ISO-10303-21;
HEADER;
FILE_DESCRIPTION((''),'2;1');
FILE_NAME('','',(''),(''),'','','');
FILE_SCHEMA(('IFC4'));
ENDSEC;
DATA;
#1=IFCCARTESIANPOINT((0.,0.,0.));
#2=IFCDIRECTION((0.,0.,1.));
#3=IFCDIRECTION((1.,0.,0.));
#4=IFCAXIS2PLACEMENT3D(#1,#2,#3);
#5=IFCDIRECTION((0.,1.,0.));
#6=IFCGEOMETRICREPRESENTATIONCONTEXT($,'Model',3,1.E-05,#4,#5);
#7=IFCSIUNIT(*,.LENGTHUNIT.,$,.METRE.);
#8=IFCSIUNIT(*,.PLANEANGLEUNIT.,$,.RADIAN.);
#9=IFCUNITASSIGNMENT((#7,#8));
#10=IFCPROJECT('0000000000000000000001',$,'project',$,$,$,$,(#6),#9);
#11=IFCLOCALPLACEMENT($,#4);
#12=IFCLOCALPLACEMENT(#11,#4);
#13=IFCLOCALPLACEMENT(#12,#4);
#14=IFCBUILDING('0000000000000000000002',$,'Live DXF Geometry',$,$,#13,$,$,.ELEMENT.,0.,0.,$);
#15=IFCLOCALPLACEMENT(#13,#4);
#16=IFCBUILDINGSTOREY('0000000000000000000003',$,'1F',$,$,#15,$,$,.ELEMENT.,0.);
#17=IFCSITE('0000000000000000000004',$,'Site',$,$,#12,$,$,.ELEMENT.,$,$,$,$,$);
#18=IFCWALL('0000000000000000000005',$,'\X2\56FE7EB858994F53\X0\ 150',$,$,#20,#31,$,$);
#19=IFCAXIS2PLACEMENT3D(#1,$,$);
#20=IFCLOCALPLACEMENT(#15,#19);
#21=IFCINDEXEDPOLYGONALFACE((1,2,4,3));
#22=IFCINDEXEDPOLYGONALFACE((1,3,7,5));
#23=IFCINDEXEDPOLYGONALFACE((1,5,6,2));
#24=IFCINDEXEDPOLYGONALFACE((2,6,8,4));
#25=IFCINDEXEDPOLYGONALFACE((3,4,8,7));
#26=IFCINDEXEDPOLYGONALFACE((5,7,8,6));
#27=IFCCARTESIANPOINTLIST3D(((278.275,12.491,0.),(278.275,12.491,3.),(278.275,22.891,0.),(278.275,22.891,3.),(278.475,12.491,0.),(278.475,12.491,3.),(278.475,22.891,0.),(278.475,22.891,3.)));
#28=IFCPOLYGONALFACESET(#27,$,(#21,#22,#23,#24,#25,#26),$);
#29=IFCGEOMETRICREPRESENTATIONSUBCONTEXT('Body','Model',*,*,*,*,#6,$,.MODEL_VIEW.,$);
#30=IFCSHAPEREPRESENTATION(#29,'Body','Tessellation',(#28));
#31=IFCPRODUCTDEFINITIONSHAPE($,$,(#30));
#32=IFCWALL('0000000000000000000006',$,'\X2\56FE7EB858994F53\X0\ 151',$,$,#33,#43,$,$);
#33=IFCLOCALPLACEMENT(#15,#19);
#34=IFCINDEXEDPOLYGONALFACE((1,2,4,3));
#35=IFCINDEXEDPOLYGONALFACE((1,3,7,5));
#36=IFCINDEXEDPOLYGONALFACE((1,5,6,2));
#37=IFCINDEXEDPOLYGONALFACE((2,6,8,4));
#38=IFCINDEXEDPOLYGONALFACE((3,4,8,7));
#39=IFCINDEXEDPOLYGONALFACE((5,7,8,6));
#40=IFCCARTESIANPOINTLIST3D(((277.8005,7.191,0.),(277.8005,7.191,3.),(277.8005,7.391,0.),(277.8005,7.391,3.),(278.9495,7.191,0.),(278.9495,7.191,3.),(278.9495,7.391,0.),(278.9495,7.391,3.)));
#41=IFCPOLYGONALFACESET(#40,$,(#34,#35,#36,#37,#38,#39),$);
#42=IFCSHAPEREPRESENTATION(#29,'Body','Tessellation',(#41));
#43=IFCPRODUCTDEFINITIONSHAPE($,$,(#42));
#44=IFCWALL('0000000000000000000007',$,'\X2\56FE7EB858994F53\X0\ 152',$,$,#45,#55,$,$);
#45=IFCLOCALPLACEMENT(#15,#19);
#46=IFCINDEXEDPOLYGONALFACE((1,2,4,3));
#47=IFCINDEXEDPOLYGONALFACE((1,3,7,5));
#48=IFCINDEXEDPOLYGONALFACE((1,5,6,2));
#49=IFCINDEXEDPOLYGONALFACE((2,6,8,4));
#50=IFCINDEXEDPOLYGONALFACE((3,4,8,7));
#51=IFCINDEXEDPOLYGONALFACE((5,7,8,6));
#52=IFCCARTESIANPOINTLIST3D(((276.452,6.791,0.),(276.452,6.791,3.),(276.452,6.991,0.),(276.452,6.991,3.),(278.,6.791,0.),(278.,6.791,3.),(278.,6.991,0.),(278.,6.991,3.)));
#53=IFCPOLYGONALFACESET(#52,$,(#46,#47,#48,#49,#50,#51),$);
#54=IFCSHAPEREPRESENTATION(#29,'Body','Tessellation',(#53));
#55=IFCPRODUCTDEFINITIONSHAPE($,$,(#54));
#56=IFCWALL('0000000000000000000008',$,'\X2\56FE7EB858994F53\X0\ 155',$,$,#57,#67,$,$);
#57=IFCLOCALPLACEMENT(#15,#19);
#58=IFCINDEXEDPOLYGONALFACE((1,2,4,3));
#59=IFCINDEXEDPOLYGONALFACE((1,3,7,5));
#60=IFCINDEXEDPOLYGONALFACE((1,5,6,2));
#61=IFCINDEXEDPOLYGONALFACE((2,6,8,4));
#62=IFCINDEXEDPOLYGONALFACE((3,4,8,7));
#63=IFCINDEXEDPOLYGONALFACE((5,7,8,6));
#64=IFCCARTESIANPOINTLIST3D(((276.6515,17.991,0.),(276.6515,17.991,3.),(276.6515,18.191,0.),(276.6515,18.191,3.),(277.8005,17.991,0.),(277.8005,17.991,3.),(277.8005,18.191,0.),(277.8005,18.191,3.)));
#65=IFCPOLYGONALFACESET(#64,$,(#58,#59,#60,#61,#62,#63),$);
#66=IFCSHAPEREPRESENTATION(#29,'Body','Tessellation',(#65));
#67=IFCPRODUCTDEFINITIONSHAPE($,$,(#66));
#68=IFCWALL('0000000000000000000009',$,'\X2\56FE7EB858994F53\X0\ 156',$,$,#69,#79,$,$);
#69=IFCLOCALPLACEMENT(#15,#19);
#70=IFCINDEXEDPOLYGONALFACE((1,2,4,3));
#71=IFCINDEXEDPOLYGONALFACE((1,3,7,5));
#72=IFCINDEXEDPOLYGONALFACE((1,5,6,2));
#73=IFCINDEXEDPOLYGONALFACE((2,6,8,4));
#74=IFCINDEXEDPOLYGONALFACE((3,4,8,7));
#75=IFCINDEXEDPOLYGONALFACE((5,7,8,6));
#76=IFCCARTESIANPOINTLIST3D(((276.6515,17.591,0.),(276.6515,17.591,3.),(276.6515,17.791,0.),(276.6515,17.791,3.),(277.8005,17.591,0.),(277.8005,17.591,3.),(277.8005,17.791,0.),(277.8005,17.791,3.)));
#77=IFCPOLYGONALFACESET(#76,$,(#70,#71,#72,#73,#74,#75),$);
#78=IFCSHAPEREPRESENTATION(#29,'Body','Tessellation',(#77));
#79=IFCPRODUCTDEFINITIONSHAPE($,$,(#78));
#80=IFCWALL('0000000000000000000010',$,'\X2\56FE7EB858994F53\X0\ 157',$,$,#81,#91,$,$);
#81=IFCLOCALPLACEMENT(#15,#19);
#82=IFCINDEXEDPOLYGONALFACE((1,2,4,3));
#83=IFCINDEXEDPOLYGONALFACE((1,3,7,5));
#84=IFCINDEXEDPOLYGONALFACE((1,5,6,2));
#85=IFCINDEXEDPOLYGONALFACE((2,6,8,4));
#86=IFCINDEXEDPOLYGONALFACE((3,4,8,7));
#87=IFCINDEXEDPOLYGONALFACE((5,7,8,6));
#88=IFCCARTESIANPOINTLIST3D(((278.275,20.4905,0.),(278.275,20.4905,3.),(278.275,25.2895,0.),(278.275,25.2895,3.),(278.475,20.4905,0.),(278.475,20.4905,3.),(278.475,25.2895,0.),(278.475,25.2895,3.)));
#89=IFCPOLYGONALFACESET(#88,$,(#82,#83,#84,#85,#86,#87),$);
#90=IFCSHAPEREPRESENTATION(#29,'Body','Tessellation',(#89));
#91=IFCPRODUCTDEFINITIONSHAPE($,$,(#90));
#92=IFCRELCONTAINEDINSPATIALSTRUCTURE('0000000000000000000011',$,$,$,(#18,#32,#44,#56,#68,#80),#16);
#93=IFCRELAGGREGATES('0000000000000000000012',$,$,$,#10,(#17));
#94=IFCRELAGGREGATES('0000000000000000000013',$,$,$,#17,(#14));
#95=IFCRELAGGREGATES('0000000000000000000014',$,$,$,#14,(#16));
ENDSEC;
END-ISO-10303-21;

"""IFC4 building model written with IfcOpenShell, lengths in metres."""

from ifc_helpers import new_model, si_unit, direction, frame, frame_2d, origin_with_axes, place, context, subcontext, project, spatial, rectangle, extrude, element, save


model = new_model("IFC4")

# Units and contexts
model_context = context("Model", 3, precision=1e-05, world=origin_with_axes(), true_north=direction((0.0, 1.0, 0.0)))
body_context = subcontext(model_context, "Body", "Model", "MODEL_VIEW")
ifc_project = project(units=[si_unit("LENGTHUNIT", "METRE"), si_unit("PLANEANGLEUNIT", "RADIAN")], contexts=[model_context])

# Site, building, storey
placement = place(None, origin_with_axes())
site_placement = place(placement, origin_with_axes())
site = spatial("IfcSite", under=ifc_project, at=site_placement, Name="Site", CompositionType="ELEMENT")
building_placement = place(site_placement, origin_with_axes())
building = spatial("IfcBuilding", under=site, at=building_placement, Name="Live DXF Geometry", CompositionType="ELEMENT", ElevationOfRefHeight=0.0, ElevationOfTerrain=0.0)
storey_placement = place(building_placement, origin_with_axes())
storey = spatial("IfcBuildingStorey", under=building, at=storey_placement, Name="1F", CompositionType="ELEMENT", Elevation=0.0)

# Walls
wall_1_placement = place(storey_placement, frame((278.375, 17.691, 0.0), z_axis=(0.0, 0.0, 1.0), x_axis=(0.0, -1.0, 0.0)))
element("IfcWall", 1, at=wall_1_placement, inside=storey, Name="图纸墙体 150", context=body_context, shape_type="SweptSolid", body=[
    extrude(rectangle(XDim=10.4, YDim=0.2, at=frame_2d((0.0, 0.0), x_axis=(1.0, 0.0, 0.0))), frame((0.0, 0.0, 0.0), z_axis=(0.0, 0.0, 1.0)), (0.0, 0.0, 1.0), 3.0),
])
wall_2_placement = place(storey_placement, frame((278.375, 7.291, 0.0), z_axis=(0.0, 0.0, 1.0), x_axis=(-1.0, 0.0, 0.0)))
element("IfcWall", 2, at=wall_2_placement, inside=storey, Name="图纸墙体 151", context=body_context, shape_type="SweptSolid", body=[
    extrude(rectangle(XDim=1.149, YDim=0.2, at=frame_2d((0.0, 0.0), x_axis=(1.0, 0.0, 0.0))), frame((0.0, 0.0, 0.0), z_axis=(0.0, 0.0, 1.0)), (0.0, 0.0, 1.0), 3.0),
])
wall_3_placement = place(storey_placement, frame((277.226, 6.891, 0.0), z_axis=(0.0, 0.0, 1.0), x_axis=(1.0, 0.0, 0.0)))
element("IfcWall", 3, at=wall_3_placement, inside=storey, Name="图纸墙体 152", context=body_context, shape_type="SweptSolid", body=[
    extrude(rectangle(XDim=1.548, YDim=0.2, at=frame_2d((0.0, 0.0), x_axis=(1.0, 0.0, 0.0))), frame((0.0, 0.0, 0.0), z_axis=(0.0, 0.0, 1.0)), (0.0, 0.0, 1.0), 3.0),
])
for number, where, z_axis, x_axis, name in (
    (4, (277.226, 18.091, 0.0), (0.0, 0.0, 1.0), (1.0, 0.0, 0.0), "图纸墙体 155"),
    (5, (277.226, 17.691, 0.0), (0.0, 0.0, 1.0), (1.0, 0.0, 0.0), "图纸墙体 156"),
):
    element("IfcWall", number, at=place(storey_placement, frame(where, z_axis=z_axis, x_axis=x_axis)), inside=storey, Name=name, context=body_context, shape_type="SweptSolid", body=[
        extrude(rectangle(XDim=1.149, YDim=0.2, at=frame_2d((0.0, 0.0), x_axis=(1.0, 0.0, 0.0))), frame((0.0, 0.0, 0.0), z_axis=(0.0, 0.0, 1.0)), (0.0, 0.0, 1.0), 3.0),
    ])
wall_4_placement = place(storey_placement, frame((278.375, 22.89, 0.0), z_axis=(0.0, 0.0, 1.0), x_axis=(0.0, -1.0, 0.0)))
element("IfcWall", 6, at=wall_4_placement, inside=storey, Name="图纸墙体 157", context=body_context, shape_type="SweptSolid", body=[
    extrude(rectangle(XDim=4.799, YDim=0.2, at=frame_2d((0.0, 0.0), x_axis=(1.0, 0.0, 0.0))), frame((0.0, 0.0, 0.0), z_axis=(0.0, 0.0, 1.0)), (0.0, 0.0, 1.0), 3.0),
])

save(model, "model.ifc")
